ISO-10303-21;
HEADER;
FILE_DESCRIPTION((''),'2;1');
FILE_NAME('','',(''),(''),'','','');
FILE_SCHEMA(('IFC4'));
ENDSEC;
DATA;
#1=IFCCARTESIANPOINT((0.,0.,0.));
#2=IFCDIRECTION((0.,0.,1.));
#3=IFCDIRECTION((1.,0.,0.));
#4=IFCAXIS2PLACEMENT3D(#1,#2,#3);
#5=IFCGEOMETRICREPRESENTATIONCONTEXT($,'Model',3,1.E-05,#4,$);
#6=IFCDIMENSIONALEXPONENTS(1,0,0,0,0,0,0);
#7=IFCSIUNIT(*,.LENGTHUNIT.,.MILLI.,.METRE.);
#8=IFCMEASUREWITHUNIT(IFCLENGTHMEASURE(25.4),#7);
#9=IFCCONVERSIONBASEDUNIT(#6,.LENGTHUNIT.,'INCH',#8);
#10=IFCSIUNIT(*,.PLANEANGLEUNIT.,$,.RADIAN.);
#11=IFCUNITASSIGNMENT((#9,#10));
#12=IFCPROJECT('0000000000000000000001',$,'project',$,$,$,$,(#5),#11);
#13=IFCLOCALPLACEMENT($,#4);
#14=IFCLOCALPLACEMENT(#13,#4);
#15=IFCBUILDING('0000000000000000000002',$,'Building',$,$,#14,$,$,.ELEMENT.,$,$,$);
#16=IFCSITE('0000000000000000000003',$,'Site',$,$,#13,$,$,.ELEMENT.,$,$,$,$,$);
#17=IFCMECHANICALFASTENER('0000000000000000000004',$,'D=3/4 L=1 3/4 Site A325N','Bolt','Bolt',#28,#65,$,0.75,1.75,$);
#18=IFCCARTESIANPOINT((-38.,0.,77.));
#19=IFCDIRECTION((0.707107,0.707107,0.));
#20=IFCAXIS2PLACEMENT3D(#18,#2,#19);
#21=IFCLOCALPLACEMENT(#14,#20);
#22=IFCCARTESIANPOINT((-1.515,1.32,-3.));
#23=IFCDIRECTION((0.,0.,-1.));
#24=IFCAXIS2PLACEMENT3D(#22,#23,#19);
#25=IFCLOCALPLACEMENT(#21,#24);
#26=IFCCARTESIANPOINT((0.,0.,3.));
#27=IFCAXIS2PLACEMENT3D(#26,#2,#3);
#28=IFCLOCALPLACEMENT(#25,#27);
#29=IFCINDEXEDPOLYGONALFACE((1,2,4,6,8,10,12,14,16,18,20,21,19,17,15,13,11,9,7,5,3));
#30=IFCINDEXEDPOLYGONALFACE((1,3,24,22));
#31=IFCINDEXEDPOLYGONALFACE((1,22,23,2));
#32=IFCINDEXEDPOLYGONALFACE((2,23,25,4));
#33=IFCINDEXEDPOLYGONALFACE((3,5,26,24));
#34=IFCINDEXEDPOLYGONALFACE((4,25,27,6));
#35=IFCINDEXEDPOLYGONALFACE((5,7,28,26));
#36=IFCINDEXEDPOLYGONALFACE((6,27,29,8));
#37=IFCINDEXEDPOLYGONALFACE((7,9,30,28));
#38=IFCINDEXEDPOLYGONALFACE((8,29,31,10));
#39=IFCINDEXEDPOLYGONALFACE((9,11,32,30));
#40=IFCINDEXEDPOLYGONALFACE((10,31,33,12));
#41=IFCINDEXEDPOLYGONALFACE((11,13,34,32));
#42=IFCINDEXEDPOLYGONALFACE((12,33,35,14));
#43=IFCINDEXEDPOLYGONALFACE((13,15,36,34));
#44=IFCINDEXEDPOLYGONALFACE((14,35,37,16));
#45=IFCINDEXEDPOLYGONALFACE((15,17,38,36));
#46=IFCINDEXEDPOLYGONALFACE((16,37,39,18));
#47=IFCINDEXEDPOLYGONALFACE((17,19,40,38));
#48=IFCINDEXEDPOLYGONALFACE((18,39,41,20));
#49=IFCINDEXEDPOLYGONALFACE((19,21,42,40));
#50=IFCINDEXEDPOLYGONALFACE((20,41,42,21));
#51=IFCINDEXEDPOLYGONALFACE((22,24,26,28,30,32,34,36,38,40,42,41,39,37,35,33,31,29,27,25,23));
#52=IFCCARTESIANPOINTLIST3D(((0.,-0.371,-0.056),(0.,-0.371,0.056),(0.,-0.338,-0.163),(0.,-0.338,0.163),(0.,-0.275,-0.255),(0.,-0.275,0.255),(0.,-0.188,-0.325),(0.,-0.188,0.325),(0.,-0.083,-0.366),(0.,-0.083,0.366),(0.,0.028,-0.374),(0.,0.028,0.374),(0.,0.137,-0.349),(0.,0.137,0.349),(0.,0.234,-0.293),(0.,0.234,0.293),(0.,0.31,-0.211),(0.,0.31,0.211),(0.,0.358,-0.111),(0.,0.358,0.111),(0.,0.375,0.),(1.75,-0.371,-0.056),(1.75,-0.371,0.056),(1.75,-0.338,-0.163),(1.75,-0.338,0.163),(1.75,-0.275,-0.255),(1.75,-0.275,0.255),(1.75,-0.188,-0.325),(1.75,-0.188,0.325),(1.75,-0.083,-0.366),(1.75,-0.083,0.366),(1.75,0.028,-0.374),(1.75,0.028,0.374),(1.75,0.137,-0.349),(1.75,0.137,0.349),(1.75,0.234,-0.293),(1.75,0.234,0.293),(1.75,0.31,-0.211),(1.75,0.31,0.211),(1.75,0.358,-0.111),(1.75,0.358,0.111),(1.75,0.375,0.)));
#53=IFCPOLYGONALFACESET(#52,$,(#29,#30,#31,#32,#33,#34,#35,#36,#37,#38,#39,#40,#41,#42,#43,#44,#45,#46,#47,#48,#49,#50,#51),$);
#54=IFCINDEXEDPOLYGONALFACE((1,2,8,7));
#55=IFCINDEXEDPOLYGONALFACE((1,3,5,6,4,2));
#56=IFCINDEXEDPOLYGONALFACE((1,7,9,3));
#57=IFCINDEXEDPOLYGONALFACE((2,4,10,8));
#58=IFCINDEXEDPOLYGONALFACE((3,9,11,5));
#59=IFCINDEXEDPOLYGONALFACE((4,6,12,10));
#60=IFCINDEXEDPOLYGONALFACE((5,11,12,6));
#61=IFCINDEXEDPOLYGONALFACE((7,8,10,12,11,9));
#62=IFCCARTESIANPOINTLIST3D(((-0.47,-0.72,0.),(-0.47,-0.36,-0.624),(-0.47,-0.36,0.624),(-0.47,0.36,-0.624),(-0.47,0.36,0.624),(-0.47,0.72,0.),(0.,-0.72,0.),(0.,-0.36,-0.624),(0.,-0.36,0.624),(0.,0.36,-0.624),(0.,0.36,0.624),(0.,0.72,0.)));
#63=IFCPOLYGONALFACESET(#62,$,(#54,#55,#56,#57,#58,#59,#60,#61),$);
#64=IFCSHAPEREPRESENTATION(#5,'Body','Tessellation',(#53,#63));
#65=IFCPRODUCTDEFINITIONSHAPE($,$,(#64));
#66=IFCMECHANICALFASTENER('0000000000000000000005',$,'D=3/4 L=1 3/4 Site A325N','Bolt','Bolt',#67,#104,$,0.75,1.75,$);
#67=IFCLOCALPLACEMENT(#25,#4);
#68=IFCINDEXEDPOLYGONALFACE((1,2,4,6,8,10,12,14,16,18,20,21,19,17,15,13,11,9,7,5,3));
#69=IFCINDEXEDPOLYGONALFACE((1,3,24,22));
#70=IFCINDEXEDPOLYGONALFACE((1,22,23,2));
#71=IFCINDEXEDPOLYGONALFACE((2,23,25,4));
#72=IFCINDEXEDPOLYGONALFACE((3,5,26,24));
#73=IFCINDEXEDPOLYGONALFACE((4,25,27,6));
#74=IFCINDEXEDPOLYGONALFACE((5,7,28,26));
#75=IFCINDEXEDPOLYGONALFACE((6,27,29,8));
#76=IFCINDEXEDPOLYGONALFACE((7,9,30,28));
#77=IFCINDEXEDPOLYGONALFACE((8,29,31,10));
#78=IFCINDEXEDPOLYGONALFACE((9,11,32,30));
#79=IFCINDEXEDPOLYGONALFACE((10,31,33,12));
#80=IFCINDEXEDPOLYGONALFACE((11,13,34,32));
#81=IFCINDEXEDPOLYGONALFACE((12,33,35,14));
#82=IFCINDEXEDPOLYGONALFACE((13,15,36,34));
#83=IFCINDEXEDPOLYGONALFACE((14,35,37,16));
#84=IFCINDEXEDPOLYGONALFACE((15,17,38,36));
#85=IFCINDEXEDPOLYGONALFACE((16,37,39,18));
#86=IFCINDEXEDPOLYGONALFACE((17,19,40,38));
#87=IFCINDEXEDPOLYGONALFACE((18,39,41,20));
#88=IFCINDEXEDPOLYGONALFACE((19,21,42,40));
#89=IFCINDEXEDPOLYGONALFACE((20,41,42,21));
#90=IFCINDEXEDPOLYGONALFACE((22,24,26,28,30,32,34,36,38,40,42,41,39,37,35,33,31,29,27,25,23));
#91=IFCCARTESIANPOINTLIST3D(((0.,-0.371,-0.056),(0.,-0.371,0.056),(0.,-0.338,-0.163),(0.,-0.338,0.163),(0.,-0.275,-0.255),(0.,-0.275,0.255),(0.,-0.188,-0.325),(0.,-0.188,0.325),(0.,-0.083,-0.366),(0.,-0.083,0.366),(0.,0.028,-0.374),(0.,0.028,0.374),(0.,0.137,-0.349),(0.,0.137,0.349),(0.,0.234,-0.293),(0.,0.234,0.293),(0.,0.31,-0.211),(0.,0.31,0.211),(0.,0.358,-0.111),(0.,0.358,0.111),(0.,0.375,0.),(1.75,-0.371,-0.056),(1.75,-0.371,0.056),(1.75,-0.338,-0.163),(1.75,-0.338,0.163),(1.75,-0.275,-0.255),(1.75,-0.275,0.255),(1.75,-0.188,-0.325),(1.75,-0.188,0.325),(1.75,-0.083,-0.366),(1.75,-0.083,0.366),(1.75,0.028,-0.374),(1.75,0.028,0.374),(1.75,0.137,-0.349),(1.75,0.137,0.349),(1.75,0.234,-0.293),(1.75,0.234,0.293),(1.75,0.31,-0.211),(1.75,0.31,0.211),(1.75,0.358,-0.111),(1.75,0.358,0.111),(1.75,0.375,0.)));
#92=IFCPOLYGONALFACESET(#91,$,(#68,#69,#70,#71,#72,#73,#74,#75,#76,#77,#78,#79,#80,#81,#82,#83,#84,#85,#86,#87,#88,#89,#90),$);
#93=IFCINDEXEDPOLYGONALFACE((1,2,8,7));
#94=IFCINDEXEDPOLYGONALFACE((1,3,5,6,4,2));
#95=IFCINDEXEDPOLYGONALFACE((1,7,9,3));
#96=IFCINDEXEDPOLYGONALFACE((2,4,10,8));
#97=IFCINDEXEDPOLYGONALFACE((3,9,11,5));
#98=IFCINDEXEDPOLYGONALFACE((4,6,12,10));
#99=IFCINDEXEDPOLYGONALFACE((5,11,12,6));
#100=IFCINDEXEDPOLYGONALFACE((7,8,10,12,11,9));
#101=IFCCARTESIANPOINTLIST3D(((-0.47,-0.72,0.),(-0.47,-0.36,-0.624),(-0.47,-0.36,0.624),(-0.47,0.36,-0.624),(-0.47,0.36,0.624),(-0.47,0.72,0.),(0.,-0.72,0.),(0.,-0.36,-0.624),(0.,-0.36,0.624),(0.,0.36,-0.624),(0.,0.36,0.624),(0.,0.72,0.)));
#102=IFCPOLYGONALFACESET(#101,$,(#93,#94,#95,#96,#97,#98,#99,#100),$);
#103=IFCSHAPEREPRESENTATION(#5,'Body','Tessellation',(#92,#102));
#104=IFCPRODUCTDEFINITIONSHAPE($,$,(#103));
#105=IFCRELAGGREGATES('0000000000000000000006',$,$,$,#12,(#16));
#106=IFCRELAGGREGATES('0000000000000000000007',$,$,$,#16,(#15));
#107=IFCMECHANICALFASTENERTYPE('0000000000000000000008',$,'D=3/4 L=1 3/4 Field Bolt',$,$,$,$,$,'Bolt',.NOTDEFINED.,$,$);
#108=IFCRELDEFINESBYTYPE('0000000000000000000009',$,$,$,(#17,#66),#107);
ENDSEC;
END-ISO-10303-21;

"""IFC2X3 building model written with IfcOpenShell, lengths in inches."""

from ifc_helpers import new_model, entity, si_unit, converted_unit, frame, origin_with_axes, origin_2d_with_axis, place, context, project, spatial, polyline, circle, outline, extrude, source, transform, mapped, type_object, type_shapes, element, save


model = new_model("IFC2X3")

# Units and contexts
model_context = context("Model", 3, precision=1e-05, world=origin_with_axes())
ifc_project = project(units=[converted_unit("LENGTHUNIT", "INCH", entity("IfcLengthMeasure", 25.4), si_unit("LENGTHUNIT", "METRE", prefix="MILLI"), dimensions=[1, 0, 0, 0, 0, 0, 0]), si_unit("PLANEANGLEUNIT", "RADIAN")], contexts=[model_context])

# Site, building
site_placement = place(None, origin_with_axes())
site = spatial("IfcSite", under=ifc_project, at=site_placement, Name="Site", CompositionType="ELEMENT")
building_placement = place(site_placement, origin_with_axes())
building = spatial("IfcBuilding", under=site, at=building_placement, Name="Building", CompositionType="ELEMENT")

# Mechanical fasteners
mechanical_fastener_type_1 = type_object("IfcMechanicalFastenerType", Name="D=3/4 L=1 3/4 Field Bolt", ElementType="Bolt")
shared_shape_1 = source(origin_with_axes(), model_context, "Body", "SweptSolid", [
    extrude(circle(Radius=0.375, at=origin_2d_with_axis()), frame((0.0, 0.0, 0.0), z_axis=(1.0, 0.0, 0.0), x_axis=(0.0, 1.0, 0.0)), (0.0, 0.0, 1.0), 1.75),
    extrude(outline(polyline([(-0.72, 0.0), (-0.36, 0.624), (0.36, 0.624), (0.72, 0.0), (0.36, -0.624), (-0.36, -0.624), (-0.72, 0.0)])), frame((0.0, 0.0, 0.0), z_axis=(1.0, 0.0, 0.0), x_axis=(0.0, 1.0, 0.0)), (0.0, 0.0, -1.0), 0.47),
])
type_shapes(mechanical_fastener_type_1, [shared_shape_1])
placement_1 = place(building_placement, frame((-38.0, 0.0, 77.0), z_axis=(0.0, 0.0, 1.0), x_axis=(0.707107, 0.707107, 0.0)))
placement_2 = place(placement_1, frame((-1.515, 1.32, -3.0), z_axis=(0.0, 0.0, -1.0), x_axis=(0.707107, 0.707107, 0.0)))
for number, where, z_axis, x_axis, name in (
    (1, (0.0, 0.0, 3.0), (0.0, 0.0, 1.0), (1.0, 0.0, 0.0), "D=3/4 L=1 3/4 Site A325N"),
    (2, (0.0, 0.0, 0.0), (0.0, 0.0, 1.0), (1.0, 0.0, 0.0), "D=3/4 L=1 3/4 Site A325N"),
):
    element("IfcMechanicalFastener", number, at=place(placement_2, frame(where, z_axis=z_axis, x_axis=x_axis)), type_object=mechanical_fastener_type_1, Name=name, Description="Bolt", ObjectType="Bolt", NominalDiameter=0.75, NominalLength=1.75, context=model_context, shape_type="MappedRepresentation", body=[
        mapped(shared_shape_1, transform((0.0, 0.0, 0.0), scale=1.0)),
    ])

save(model, "model.ifc")
